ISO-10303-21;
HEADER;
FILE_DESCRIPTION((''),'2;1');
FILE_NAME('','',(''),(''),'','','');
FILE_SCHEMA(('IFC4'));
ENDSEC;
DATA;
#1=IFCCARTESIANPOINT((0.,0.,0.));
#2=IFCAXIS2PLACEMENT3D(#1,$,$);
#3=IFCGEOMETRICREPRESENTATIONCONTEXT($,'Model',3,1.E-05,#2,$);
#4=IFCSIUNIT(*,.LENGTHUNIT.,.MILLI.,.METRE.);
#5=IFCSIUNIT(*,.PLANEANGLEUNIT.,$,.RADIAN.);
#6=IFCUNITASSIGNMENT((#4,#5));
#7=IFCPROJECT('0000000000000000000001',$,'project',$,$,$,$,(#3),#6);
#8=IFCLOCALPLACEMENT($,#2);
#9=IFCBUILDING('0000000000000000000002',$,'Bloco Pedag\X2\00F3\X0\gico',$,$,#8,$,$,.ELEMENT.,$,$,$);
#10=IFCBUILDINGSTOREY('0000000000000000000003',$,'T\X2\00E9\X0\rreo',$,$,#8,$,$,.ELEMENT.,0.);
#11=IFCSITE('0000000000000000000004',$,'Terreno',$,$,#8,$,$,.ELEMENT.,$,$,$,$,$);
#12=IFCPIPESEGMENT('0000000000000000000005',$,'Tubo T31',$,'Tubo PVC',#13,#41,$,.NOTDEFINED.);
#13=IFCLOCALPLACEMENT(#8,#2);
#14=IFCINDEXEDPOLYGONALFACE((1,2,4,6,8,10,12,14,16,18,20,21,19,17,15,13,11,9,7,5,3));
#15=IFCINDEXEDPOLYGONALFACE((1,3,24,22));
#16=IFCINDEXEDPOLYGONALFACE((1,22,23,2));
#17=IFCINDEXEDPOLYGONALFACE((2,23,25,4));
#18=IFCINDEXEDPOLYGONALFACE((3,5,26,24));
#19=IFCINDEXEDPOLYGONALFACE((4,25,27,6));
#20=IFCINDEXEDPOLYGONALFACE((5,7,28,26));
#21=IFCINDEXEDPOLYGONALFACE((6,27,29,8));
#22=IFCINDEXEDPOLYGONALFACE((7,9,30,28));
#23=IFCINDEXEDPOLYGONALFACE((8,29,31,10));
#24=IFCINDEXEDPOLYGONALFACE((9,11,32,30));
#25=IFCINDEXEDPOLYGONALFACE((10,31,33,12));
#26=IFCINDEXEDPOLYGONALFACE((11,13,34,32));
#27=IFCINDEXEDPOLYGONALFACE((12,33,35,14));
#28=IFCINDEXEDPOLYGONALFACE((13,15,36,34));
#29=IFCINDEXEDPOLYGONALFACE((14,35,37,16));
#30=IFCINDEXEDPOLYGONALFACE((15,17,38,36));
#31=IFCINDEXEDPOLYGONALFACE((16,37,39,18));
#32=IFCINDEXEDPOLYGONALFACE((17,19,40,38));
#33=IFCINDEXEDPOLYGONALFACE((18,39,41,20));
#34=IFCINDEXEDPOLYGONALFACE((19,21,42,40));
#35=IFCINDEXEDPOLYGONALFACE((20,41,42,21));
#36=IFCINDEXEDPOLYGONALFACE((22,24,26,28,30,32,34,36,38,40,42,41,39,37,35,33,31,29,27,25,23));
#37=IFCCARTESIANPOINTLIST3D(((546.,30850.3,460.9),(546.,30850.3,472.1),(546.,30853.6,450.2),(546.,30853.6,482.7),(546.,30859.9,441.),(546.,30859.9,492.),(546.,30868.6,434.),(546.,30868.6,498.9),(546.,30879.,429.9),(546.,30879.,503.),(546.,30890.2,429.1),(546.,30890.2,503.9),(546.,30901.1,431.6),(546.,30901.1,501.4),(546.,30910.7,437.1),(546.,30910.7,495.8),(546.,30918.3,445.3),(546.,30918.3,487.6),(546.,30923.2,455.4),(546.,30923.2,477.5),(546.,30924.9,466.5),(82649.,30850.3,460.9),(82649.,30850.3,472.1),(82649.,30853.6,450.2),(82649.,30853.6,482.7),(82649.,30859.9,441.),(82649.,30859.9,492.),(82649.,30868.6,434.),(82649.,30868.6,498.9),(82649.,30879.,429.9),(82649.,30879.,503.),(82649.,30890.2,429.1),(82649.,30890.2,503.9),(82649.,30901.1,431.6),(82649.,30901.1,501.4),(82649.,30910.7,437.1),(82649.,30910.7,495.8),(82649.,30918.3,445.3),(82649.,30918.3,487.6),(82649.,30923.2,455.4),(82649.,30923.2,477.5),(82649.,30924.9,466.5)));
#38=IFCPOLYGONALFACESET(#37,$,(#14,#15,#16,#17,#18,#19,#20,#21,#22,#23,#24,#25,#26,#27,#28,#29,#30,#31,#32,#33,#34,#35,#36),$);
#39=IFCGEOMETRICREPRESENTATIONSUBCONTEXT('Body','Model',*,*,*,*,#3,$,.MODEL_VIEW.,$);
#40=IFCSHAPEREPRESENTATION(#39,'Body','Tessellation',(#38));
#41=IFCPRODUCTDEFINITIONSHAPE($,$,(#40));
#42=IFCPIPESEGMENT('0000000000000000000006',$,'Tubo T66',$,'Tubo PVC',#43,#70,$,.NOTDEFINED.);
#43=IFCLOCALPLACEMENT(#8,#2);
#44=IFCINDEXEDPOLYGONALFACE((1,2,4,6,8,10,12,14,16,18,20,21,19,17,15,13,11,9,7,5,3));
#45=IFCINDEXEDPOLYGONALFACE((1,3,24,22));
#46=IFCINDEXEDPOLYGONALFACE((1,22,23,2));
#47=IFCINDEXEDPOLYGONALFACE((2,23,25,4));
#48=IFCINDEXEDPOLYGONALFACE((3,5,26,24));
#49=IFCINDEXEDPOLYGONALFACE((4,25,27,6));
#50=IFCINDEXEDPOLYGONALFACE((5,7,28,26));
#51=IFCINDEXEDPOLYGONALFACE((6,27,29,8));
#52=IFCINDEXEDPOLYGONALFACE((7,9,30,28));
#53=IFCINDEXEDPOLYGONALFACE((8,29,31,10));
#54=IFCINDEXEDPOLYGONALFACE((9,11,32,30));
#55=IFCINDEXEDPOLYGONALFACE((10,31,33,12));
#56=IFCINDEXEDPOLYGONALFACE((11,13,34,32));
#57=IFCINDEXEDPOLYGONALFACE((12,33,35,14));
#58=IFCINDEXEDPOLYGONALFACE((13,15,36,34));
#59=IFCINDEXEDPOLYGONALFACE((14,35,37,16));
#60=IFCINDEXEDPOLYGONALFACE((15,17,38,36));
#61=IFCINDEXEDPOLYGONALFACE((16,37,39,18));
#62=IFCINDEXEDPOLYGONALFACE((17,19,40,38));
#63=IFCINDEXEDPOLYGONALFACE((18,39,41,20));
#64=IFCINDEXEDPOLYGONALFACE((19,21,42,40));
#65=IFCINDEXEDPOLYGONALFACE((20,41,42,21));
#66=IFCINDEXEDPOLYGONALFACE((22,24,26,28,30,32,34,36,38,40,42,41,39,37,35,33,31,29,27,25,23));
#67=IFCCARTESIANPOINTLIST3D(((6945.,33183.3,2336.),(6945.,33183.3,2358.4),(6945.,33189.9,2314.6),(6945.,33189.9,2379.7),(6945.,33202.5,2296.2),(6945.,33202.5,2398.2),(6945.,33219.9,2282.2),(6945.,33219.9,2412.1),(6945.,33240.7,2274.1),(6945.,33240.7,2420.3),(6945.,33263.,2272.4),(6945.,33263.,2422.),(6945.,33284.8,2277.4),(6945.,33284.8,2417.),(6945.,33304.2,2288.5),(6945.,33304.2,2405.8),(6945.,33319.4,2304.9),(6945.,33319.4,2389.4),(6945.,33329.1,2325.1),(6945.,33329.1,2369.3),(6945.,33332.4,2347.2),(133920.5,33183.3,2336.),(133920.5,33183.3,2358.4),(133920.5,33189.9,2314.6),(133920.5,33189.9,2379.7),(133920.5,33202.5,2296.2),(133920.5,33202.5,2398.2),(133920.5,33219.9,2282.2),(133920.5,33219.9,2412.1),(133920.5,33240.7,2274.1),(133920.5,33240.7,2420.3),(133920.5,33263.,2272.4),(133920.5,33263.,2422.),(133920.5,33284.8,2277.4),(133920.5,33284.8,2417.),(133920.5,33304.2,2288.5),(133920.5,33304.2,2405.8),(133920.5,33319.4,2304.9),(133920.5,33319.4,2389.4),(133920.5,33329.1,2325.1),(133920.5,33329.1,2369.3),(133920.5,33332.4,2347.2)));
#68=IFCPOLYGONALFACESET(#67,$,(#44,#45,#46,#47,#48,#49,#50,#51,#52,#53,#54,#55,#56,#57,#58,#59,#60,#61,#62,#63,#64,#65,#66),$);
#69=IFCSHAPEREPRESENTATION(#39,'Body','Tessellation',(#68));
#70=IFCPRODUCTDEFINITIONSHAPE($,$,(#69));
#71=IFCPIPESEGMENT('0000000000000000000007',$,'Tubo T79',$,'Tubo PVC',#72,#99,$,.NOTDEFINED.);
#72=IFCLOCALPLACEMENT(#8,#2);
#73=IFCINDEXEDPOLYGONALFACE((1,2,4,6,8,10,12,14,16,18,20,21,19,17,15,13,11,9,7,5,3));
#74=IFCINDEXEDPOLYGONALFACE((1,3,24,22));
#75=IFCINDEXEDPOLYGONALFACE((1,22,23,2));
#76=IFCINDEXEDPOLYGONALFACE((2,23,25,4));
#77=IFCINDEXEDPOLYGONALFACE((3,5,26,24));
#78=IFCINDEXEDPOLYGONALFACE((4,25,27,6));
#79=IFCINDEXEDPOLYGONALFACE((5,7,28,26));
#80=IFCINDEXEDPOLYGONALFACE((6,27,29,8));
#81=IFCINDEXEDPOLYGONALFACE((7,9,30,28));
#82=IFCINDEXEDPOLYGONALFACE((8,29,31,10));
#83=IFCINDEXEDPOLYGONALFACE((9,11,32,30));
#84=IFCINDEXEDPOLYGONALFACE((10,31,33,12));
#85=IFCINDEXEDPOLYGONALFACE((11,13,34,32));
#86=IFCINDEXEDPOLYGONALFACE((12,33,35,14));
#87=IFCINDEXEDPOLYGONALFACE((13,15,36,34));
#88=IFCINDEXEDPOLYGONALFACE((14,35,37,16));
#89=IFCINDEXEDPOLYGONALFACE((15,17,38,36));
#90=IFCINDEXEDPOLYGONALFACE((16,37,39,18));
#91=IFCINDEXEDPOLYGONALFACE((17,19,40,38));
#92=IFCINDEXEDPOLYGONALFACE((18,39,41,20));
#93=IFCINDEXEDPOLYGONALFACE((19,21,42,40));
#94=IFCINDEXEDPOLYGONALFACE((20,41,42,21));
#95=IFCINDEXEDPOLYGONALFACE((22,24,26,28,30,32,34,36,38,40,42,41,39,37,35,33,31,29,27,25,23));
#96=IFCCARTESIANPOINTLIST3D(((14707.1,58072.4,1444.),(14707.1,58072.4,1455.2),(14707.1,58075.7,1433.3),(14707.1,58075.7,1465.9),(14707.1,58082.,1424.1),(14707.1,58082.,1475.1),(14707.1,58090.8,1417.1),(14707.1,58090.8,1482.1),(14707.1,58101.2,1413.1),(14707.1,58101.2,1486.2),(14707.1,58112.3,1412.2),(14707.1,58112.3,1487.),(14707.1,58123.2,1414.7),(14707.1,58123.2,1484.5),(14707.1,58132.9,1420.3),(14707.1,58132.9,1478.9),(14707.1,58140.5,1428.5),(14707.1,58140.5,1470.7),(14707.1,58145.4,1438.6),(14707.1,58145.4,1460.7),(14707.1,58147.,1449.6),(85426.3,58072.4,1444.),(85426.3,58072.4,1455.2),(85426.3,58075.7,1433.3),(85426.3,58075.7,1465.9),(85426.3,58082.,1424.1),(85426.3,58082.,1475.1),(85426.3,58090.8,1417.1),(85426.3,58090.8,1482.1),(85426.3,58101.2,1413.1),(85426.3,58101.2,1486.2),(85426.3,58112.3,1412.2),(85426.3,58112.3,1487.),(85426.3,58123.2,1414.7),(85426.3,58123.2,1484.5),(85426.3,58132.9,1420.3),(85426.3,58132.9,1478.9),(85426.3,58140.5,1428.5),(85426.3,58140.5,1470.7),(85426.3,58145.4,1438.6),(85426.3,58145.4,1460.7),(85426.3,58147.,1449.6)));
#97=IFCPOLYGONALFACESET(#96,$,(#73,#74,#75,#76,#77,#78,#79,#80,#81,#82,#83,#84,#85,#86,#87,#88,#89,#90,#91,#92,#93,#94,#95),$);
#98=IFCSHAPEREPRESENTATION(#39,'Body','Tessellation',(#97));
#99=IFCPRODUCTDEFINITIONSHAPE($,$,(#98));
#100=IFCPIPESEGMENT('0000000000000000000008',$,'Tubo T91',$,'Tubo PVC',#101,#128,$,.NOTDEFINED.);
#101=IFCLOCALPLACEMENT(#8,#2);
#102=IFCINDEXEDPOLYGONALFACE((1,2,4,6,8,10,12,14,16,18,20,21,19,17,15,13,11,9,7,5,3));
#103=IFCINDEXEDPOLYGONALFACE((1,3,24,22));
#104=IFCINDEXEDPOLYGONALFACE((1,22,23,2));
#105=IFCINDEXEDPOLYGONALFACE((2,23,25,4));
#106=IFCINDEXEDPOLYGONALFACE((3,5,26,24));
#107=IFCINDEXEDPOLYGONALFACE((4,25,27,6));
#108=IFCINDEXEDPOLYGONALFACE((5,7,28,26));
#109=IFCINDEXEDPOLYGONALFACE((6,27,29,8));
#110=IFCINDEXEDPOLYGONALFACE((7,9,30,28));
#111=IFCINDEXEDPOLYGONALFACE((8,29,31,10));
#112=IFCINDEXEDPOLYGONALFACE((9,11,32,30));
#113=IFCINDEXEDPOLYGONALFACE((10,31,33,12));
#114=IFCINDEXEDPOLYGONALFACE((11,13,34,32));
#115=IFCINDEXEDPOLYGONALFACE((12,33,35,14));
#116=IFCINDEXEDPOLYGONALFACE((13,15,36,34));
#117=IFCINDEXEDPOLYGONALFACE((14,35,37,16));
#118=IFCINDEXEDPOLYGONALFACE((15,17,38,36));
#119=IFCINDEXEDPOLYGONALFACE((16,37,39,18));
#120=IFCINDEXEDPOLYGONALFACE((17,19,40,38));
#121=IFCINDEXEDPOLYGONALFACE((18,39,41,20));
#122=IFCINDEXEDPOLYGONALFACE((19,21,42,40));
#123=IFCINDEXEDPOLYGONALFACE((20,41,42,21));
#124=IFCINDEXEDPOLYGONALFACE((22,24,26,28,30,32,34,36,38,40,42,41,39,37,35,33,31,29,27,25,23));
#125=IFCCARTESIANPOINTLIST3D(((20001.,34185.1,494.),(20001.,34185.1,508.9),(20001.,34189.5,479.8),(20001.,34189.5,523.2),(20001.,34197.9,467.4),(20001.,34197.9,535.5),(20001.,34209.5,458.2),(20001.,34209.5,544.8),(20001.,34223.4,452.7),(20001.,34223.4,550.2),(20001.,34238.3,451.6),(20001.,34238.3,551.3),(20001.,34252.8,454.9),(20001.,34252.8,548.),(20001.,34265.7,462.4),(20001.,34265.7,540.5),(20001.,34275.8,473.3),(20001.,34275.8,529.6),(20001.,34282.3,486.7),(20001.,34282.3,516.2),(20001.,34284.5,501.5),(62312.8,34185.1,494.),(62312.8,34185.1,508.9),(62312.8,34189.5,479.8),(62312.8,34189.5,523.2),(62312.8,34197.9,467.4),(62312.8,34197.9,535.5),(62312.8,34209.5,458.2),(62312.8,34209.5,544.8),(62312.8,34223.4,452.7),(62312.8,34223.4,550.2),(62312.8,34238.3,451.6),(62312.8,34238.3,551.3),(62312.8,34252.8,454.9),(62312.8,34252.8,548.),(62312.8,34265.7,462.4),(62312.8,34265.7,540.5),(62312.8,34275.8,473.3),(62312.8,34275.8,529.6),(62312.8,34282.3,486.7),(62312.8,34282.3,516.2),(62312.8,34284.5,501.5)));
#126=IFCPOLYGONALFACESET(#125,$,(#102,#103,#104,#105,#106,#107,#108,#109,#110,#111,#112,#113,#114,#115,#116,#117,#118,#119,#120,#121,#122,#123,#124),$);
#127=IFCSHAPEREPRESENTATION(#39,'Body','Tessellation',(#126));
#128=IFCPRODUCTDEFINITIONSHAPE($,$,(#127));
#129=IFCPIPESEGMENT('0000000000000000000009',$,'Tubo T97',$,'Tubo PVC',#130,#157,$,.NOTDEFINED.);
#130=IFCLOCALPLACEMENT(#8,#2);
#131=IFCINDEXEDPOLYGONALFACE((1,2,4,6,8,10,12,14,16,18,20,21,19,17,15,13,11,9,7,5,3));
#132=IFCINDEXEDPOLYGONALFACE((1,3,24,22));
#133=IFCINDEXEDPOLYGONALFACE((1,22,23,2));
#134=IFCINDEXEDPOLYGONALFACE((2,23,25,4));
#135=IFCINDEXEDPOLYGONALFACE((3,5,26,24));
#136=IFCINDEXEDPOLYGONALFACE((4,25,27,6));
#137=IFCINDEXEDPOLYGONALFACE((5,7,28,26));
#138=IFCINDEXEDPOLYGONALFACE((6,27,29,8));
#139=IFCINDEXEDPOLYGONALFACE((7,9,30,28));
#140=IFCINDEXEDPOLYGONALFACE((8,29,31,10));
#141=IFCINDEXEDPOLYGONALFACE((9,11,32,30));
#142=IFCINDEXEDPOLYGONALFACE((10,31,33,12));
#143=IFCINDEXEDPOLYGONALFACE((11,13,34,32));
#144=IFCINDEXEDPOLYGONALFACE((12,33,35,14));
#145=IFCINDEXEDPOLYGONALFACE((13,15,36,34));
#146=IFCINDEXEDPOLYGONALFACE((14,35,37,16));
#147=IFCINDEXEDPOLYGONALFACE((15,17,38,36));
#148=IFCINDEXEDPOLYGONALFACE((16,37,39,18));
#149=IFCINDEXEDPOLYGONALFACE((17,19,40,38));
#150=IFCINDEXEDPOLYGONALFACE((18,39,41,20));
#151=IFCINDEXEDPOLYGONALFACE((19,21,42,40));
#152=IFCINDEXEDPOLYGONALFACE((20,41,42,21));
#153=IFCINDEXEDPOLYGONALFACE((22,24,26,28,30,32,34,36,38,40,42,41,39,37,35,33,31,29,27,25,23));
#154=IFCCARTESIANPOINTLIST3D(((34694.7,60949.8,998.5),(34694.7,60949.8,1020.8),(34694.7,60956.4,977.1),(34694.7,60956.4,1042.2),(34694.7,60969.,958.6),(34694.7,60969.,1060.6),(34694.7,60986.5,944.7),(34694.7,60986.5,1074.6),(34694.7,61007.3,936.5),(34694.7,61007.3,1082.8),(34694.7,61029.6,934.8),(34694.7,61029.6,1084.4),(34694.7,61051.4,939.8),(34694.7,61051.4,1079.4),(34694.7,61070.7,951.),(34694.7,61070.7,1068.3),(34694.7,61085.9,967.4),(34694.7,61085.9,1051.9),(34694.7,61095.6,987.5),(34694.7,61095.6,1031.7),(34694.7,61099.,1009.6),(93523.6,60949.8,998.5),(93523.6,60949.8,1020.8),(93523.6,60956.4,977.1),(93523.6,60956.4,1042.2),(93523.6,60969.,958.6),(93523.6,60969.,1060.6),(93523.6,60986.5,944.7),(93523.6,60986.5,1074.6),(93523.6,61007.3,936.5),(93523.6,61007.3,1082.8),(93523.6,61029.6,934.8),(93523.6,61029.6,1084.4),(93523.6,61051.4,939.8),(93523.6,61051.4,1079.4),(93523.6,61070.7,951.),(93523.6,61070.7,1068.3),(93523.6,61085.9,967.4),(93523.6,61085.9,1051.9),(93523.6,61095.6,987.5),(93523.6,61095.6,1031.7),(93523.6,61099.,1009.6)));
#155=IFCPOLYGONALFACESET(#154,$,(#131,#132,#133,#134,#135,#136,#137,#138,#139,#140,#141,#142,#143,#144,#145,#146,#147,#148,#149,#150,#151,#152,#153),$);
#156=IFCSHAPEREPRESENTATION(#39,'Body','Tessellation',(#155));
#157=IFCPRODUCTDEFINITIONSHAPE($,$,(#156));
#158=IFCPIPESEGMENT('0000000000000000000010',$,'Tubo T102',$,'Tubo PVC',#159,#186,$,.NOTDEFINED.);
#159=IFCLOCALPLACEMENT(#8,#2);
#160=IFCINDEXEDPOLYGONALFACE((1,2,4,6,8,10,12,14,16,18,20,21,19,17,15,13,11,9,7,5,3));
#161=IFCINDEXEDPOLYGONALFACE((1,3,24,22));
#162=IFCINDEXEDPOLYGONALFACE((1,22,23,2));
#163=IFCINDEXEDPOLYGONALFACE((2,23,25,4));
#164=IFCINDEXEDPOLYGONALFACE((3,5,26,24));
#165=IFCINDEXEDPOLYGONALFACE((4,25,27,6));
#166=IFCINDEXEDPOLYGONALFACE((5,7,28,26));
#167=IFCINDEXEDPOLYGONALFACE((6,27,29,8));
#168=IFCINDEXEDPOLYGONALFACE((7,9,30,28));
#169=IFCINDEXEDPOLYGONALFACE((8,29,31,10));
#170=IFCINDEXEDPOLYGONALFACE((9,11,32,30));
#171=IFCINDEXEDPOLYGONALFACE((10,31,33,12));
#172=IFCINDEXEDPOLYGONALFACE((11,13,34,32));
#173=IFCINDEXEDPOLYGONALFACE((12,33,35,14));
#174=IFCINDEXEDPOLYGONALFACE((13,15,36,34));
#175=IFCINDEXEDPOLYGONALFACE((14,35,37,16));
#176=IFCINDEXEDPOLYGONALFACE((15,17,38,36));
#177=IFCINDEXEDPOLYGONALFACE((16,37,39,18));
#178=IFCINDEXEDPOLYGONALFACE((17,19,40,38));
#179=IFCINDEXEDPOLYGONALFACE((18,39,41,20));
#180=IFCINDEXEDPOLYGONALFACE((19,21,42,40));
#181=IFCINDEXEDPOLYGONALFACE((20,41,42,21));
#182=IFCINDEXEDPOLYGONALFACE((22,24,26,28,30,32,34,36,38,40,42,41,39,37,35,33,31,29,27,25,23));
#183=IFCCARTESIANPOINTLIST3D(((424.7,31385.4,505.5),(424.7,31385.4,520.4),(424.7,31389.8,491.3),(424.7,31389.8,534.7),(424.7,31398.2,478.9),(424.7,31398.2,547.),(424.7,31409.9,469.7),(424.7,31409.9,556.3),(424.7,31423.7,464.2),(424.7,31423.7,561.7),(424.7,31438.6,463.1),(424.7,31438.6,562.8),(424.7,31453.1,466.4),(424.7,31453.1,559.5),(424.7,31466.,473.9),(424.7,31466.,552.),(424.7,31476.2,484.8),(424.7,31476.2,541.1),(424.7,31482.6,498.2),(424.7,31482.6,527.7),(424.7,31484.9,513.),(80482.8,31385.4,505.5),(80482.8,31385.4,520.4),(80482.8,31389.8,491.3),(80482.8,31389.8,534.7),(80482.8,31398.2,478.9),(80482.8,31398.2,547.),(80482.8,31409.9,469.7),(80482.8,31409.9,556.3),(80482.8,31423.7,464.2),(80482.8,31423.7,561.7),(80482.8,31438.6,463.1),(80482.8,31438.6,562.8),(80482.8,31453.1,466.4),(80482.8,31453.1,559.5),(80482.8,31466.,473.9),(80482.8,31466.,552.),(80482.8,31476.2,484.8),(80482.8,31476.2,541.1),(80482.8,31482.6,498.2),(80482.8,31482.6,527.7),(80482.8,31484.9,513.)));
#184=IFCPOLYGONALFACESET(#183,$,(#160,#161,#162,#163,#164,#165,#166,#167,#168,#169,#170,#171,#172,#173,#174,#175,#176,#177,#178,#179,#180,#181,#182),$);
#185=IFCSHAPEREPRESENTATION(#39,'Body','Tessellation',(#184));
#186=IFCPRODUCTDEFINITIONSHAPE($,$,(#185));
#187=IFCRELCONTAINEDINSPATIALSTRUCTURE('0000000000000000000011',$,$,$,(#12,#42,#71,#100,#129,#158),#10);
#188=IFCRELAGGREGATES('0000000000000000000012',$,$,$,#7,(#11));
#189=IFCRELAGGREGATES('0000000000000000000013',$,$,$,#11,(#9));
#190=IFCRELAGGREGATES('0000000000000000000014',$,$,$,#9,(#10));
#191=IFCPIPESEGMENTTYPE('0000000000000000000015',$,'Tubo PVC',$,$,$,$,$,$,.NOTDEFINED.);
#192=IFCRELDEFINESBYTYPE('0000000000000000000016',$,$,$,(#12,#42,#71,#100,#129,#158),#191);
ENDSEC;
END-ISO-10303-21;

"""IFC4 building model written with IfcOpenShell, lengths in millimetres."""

from ifc_helpers import new_model, si_unit, frame, origin, origin_2d, place, context, subcontext, project, spatial, circle, extrude, type_object, element, save


model = new_model("IFC4")

# Units and contexts
model_context = context("Model", 3, precision=1e-05, world=origin())
body_context = subcontext(model_context, "Body", "Model", "MODEL_VIEW")
ifc_project = project(units=[si_unit("LENGTHUNIT", "METRE", prefix="MILLI"), si_unit("PLANEANGLEUNIT", "RADIAN")], contexts=[model_context])

# Site, building, storey
placement = place(None, origin())
site = spatial("IfcSite", under=ifc_project, at=placement, Name="Terreno", CompositionType="ELEMENT")
building = spatial("IfcBuilding", under=site, at=placement, Name="Bloco Pedagógico", CompositionType="ELEMENT")
storey = spatial("IfcBuildingStorey", under=building, at=placement, Name="Térreo", CompositionType="ELEMENT", Elevation=0.0)

# Pipe segments
pipe_segment_type = type_object("IfcPipeSegmentType", Name="Tubo PVC", PredefinedType="NOTDEFINED")
pipe_segment_1_placement = place(None, frame((546.0, 30887.4, 466.5), z_axis=(1.0, 0.0, 0.0), x_axis=(0.0, 1.0, 0.0)))
element("IfcPipeSegment", 1, at=pipe_segment_1_placement, inside=storey, type_object=pipe_segment_type, Name="Tubo T31", ObjectType="Tubo PVC", PredefinedType="NOTDEFINED", context=body_context, shape_type="SweptSolid", body=[
    extrude(circle(Radius=37.5, at=origin_2d()), None, (0.0, 0.0, 1.0), 82102.9),
])
pipe_segment_2_placement = place(None, frame((6945.0, 33257.4, 2347.2), z_axis=(1.0, 0.0, 0.0), x_axis=(0.0, 1.0, 0.0)))
element("IfcPipeSegment", 2, at=pipe_segment_2_placement, inside=storey, type_object=pipe_segment_type, Name="Tubo T66", ObjectType="Tubo PVC", PredefinedType="NOTDEFINED", context=body_context, shape_type="SweptSolid", body=[
    extrude(circle(Radius=75.0, at=origin_2d()), None, (0.0, 0.0, 1.0), 126975.5),
])
pipe_segment_3_placement = place(None, frame((14707.1, 58109.5, 1449.6), z_axis=(1.0, 0.0, 0.0), x_axis=(0.0, 1.0, 0.0)))
element("IfcPipeSegment", 3, at=pipe_segment_3_placement, inside=storey, type_object=pipe_segment_type, Name="Tubo T79", ObjectType="Tubo PVC", PredefinedType="NOTDEFINED", context=body_context, shape_type="SweptSolid", body=[
    extrude(circle(Radius=37.5, at=origin_2d()), None, (0.0, 0.0, 1.0), 70719.3),
])
pipe_segment_4_placement = place(None, frame((20001.0, 34234.5, 501.5), z_axis=(1.0, 0.0, 0.0), x_axis=(0.0, 1.0, 0.0)))
element("IfcPipeSegment", 4, at=pipe_segment_4_placement, inside=storey, type_object=pipe_segment_type, Name="Tubo T91", ObjectType="Tubo PVC", PredefinedType="NOTDEFINED", context=body_context, shape_type="SweptSolid", body=[
    extrude(circle(Radius=50.0, at=origin_2d()), None, (0.0, 0.0, 1.0), 42311.8),
])
pipe_segment_5_placement = place(None, frame((34694.7, 61024.0, 1009.6), z_axis=(1.0, 0.0, 0.0), x_axis=(0.0, 1.0, 0.0)))
element("IfcPipeSegment", 5, at=pipe_segment_5_placement, inside=storey, type_object=pipe_segment_type, Name="Tubo T97", ObjectType="Tubo PVC", PredefinedType="NOTDEFINED", context=body_context, shape_type="SweptSolid", body=[
    extrude(circle(Radius=75.0, at=origin_2d()), None, (0.0, 0.0, 1.0), 58828.9),
])
pipe_segment_6_placement = place(None, frame((424.7, 31434.9, 513.0), z_axis=(1.0, 0.0, 0.0), x_axis=(0.0, 1.0, 0.0)))
element("IfcPipeSegment", 6, at=pipe_segment_6_placement, inside=storey, type_object=pipe_segment_type, Name="Tubo T102", ObjectType="Tubo PVC", PredefinedType="NOTDEFINED", context=body_context, shape_type="SweptSolid", body=[
    extrude(circle(Radius=50.0, at=origin_2d()), None, (0.0, 0.0, 1.0), 80058.1),
])

save(model, "model.ifc")
